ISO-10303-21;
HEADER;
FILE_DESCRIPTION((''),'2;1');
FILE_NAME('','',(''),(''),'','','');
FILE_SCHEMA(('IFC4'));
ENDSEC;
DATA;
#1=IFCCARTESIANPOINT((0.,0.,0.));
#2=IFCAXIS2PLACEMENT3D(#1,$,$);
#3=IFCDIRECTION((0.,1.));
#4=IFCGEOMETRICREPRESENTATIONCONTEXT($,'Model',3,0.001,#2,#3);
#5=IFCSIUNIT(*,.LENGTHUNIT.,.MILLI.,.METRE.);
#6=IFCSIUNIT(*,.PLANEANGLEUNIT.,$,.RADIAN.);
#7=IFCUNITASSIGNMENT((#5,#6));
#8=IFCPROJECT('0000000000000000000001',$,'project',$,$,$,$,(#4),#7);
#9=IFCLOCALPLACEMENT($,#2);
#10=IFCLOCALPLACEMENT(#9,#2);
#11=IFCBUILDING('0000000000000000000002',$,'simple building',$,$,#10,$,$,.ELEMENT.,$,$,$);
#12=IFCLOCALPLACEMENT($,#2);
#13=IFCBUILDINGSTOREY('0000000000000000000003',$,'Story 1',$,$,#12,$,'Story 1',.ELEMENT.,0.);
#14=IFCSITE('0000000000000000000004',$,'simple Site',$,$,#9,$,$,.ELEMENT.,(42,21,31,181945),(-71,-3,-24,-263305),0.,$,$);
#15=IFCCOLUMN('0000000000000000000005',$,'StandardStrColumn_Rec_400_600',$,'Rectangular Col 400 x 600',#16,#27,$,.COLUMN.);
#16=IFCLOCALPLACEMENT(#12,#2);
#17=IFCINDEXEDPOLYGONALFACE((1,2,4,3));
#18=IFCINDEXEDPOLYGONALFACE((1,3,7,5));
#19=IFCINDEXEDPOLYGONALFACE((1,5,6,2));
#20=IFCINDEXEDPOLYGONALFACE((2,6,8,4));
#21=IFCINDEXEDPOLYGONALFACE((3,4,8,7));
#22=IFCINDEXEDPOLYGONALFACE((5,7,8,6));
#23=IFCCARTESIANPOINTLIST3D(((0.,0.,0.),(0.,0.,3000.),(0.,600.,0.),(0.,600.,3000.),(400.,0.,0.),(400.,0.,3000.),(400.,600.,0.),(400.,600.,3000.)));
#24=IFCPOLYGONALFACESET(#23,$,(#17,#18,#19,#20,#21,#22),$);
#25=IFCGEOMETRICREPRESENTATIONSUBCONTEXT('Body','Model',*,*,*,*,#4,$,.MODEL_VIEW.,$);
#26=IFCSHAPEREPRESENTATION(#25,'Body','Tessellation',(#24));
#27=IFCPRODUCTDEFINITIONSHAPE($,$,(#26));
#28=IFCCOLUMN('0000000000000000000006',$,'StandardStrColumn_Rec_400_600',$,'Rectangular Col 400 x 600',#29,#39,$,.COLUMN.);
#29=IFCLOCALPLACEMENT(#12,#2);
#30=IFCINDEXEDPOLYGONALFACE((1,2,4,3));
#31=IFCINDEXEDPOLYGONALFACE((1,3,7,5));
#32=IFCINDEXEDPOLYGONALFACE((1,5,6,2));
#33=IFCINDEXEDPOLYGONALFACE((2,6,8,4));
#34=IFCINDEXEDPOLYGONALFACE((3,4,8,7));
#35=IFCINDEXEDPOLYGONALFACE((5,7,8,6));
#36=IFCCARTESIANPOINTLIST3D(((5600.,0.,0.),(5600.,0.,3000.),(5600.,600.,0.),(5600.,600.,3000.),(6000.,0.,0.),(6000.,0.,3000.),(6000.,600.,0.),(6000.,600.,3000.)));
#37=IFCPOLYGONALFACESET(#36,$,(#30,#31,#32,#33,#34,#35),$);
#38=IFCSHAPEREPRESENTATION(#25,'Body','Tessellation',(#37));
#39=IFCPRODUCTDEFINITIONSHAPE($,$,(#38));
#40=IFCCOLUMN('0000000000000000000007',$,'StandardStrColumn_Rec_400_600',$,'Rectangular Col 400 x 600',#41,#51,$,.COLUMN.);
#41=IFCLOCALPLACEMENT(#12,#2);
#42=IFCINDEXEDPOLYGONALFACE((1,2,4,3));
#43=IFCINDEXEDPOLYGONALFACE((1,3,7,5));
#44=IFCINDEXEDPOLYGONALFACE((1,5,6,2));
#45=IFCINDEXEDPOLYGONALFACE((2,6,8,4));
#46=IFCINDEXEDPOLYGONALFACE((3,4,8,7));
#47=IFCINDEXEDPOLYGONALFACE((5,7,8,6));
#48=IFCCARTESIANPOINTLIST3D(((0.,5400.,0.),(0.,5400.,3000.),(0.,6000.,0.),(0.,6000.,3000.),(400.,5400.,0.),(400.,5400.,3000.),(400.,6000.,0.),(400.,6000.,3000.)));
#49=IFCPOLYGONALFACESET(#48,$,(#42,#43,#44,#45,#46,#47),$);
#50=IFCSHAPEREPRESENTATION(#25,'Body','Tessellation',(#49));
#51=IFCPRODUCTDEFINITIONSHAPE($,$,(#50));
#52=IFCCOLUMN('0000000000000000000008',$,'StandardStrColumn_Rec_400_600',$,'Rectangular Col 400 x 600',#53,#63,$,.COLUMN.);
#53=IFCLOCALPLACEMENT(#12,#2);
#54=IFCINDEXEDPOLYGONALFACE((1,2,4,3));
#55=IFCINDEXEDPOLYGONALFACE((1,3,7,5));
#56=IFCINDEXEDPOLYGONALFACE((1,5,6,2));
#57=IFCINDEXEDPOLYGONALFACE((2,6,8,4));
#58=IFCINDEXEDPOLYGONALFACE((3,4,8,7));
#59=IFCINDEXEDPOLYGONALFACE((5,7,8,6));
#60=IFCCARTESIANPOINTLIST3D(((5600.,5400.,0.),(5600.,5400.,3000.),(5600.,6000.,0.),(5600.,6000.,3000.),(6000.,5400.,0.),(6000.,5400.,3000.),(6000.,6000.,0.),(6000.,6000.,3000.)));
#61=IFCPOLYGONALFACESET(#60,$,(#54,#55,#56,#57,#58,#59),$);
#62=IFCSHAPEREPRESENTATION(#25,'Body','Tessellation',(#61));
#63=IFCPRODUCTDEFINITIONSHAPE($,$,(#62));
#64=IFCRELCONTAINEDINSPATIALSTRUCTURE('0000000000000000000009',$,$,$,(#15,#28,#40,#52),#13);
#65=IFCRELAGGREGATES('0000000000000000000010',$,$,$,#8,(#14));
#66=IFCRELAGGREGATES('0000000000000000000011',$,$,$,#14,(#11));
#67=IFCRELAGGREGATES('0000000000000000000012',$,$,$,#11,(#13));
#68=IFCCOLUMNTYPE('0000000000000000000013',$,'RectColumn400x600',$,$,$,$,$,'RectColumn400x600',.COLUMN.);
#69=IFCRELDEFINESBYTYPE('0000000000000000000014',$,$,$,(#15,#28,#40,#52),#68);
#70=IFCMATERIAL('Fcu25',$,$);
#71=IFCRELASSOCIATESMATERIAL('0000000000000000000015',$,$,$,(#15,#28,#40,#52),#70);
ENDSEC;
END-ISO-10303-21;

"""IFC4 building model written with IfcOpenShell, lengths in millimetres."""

from ifc_helpers import new_model, si_unit, direction, frame, origin, origin_with_axes, origin_2d_with_axis, place, context, subcontext, project, spatial, rectangle, extrude, material, material_profile, profile_set, profile_usage, type_object, element, save


model = new_model("IFC4")

# Units and contexts
model_context = context("Model", 3, precision=0.001, world=origin(), true_north=direction((0.0, 1.0)))
body_context = subcontext(model_context, "Body", "Model", "MODEL_VIEW")
ifc_project = project(units=[si_unit("LENGTHUNIT", "METRE", prefix="MILLI"), si_unit("PLANEANGLEUNIT", "RADIAN")], contexts=[model_context])

# Site, building, storey
site_placement = place(None, origin())
site = spatial("IfcSite", under=ifc_project, at=site_placement, Name="simple Site", CompositionType="ELEMENT", RefLatitude=(42, 21, 31, 181945), RefLongitude=(-71, -3, -24, -263305), RefElevation=0.0)
building_placement = place(site_placement, origin())
building = spatial("IfcBuilding", under=site, at=building_placement, Name="simple building", CompositionType="ELEMENT")
storey_placement = place(None, origin())
storey = spatial("IfcBuildingStorey", under=building, at=storey_placement, Name="Story 1", LongName="Story 1", CompositionType="ELEMENT", Elevation=0.0)

# Columns
ifc_material = material(Name="Fcu25")
ifc_material_profile = material_profile(ifc_material, rectangle(XDim=400.0, YDim=600.0, at=origin_2d_with_axis()))
ifc_profile_set = profile_set([ifc_material_profile])
ifc_profile_usage_1 = profile_usage(ifc_profile_set, cardinal=7)
column_type = type_object("IfcColumnType", Name="RectColumn400x600", ElementType="RectColumn400x600", PredefinedType="COLUMN")
column_1_placement = place(None, frame((200.0, 300.0, 0.0), z_axis=(0.0, 0.0, 1.0), x_axis=(1.0, 0.0, 0.0)))
element("IfcColumn", 1, at=column_1_placement, inside=storey, type_object=column_type, material=ifc_profile_usage_1, Name="StandardStrColumn_Rec_400_600", ObjectType="Rectangular Col 400 x 600", PredefinedType="COLUMN", context=body_context, shape_type="SweptSolid", body=[
    extrude(rectangle(XDim=400.0, YDim=600.0, at=origin_2d_with_axis()), origin_with_axes(), (0.0, 0.0, 1.0), 3000.0),
])
ifc_profile_usage_2 = profile_usage(ifc_profile_set, cardinal=9)
column_2_placement = place(None, frame((5800.0, 300.0, 0.0), z_axis=(0.0, 0.0, 1.0), x_axis=(1.0, 0.0, 0.0)))
element("IfcColumn", 2, at=column_2_placement, inside=storey, type_object=column_type, material=ifc_profile_usage_2, Name="StandardStrColumn_Rec_400_600", ObjectType="Rectangular Col 400 x 600", PredefinedType="COLUMN", context=body_context, shape_type="SweptSolid", body=[
    extrude(rectangle(XDim=400.0, YDim=600.0, at=origin_2d_with_axis()), origin_with_axes(), (0.0, 0.0, 1.0), 3000.0),
])
ifc_profile_usage_3 = profile_usage(ifc_profile_set, cardinal=1)
column_3_placement = place(None, frame((200.0, 5700.0, 0.0), z_axis=(0.0, 0.0, 1.0), x_axis=(1.0, 0.0, 0.0)))
element("IfcColumn", 3, at=column_3_placement, inside=storey, type_object=column_type, material=ifc_profile_usage_3, Name="StandardStrColumn_Rec_400_600", ObjectType="Rectangular Col 400 x 600", PredefinedType="COLUMN", context=body_context, shape_type="SweptSolid", body=[
    extrude(rectangle(XDim=400.0, YDim=600.0, at=origin_2d_with_axis()), origin_with_axes(), (0.0, 0.0, 1.0), 3000.0),
])
ifc_profile_usage_4 = profile_usage(ifc_profile_set, cardinal=3)
column_4_placement = place(None, frame((5800.0, 5700.0, 0.0), z_axis=(0.0, 0.0, 1.0), x_axis=(1.0, 0.0, 0.0)))
element("IfcColumn", 4, at=column_4_placement, inside=storey, type_object=column_type, material=ifc_profile_usage_4, Name="StandardStrColumn_Rec_400_600", ObjectType="Rectangular Col 400 x 600", PredefinedType="COLUMN", context=body_context, shape_type="SweptSolid", body=[
    extrude(rectangle(XDim=400.0, YDim=600.0, at=origin_2d_with_axis()), origin_with_axes(), (0.0, 0.0, 1.0), 3000.0),
])

save(model, "model.ifc")
